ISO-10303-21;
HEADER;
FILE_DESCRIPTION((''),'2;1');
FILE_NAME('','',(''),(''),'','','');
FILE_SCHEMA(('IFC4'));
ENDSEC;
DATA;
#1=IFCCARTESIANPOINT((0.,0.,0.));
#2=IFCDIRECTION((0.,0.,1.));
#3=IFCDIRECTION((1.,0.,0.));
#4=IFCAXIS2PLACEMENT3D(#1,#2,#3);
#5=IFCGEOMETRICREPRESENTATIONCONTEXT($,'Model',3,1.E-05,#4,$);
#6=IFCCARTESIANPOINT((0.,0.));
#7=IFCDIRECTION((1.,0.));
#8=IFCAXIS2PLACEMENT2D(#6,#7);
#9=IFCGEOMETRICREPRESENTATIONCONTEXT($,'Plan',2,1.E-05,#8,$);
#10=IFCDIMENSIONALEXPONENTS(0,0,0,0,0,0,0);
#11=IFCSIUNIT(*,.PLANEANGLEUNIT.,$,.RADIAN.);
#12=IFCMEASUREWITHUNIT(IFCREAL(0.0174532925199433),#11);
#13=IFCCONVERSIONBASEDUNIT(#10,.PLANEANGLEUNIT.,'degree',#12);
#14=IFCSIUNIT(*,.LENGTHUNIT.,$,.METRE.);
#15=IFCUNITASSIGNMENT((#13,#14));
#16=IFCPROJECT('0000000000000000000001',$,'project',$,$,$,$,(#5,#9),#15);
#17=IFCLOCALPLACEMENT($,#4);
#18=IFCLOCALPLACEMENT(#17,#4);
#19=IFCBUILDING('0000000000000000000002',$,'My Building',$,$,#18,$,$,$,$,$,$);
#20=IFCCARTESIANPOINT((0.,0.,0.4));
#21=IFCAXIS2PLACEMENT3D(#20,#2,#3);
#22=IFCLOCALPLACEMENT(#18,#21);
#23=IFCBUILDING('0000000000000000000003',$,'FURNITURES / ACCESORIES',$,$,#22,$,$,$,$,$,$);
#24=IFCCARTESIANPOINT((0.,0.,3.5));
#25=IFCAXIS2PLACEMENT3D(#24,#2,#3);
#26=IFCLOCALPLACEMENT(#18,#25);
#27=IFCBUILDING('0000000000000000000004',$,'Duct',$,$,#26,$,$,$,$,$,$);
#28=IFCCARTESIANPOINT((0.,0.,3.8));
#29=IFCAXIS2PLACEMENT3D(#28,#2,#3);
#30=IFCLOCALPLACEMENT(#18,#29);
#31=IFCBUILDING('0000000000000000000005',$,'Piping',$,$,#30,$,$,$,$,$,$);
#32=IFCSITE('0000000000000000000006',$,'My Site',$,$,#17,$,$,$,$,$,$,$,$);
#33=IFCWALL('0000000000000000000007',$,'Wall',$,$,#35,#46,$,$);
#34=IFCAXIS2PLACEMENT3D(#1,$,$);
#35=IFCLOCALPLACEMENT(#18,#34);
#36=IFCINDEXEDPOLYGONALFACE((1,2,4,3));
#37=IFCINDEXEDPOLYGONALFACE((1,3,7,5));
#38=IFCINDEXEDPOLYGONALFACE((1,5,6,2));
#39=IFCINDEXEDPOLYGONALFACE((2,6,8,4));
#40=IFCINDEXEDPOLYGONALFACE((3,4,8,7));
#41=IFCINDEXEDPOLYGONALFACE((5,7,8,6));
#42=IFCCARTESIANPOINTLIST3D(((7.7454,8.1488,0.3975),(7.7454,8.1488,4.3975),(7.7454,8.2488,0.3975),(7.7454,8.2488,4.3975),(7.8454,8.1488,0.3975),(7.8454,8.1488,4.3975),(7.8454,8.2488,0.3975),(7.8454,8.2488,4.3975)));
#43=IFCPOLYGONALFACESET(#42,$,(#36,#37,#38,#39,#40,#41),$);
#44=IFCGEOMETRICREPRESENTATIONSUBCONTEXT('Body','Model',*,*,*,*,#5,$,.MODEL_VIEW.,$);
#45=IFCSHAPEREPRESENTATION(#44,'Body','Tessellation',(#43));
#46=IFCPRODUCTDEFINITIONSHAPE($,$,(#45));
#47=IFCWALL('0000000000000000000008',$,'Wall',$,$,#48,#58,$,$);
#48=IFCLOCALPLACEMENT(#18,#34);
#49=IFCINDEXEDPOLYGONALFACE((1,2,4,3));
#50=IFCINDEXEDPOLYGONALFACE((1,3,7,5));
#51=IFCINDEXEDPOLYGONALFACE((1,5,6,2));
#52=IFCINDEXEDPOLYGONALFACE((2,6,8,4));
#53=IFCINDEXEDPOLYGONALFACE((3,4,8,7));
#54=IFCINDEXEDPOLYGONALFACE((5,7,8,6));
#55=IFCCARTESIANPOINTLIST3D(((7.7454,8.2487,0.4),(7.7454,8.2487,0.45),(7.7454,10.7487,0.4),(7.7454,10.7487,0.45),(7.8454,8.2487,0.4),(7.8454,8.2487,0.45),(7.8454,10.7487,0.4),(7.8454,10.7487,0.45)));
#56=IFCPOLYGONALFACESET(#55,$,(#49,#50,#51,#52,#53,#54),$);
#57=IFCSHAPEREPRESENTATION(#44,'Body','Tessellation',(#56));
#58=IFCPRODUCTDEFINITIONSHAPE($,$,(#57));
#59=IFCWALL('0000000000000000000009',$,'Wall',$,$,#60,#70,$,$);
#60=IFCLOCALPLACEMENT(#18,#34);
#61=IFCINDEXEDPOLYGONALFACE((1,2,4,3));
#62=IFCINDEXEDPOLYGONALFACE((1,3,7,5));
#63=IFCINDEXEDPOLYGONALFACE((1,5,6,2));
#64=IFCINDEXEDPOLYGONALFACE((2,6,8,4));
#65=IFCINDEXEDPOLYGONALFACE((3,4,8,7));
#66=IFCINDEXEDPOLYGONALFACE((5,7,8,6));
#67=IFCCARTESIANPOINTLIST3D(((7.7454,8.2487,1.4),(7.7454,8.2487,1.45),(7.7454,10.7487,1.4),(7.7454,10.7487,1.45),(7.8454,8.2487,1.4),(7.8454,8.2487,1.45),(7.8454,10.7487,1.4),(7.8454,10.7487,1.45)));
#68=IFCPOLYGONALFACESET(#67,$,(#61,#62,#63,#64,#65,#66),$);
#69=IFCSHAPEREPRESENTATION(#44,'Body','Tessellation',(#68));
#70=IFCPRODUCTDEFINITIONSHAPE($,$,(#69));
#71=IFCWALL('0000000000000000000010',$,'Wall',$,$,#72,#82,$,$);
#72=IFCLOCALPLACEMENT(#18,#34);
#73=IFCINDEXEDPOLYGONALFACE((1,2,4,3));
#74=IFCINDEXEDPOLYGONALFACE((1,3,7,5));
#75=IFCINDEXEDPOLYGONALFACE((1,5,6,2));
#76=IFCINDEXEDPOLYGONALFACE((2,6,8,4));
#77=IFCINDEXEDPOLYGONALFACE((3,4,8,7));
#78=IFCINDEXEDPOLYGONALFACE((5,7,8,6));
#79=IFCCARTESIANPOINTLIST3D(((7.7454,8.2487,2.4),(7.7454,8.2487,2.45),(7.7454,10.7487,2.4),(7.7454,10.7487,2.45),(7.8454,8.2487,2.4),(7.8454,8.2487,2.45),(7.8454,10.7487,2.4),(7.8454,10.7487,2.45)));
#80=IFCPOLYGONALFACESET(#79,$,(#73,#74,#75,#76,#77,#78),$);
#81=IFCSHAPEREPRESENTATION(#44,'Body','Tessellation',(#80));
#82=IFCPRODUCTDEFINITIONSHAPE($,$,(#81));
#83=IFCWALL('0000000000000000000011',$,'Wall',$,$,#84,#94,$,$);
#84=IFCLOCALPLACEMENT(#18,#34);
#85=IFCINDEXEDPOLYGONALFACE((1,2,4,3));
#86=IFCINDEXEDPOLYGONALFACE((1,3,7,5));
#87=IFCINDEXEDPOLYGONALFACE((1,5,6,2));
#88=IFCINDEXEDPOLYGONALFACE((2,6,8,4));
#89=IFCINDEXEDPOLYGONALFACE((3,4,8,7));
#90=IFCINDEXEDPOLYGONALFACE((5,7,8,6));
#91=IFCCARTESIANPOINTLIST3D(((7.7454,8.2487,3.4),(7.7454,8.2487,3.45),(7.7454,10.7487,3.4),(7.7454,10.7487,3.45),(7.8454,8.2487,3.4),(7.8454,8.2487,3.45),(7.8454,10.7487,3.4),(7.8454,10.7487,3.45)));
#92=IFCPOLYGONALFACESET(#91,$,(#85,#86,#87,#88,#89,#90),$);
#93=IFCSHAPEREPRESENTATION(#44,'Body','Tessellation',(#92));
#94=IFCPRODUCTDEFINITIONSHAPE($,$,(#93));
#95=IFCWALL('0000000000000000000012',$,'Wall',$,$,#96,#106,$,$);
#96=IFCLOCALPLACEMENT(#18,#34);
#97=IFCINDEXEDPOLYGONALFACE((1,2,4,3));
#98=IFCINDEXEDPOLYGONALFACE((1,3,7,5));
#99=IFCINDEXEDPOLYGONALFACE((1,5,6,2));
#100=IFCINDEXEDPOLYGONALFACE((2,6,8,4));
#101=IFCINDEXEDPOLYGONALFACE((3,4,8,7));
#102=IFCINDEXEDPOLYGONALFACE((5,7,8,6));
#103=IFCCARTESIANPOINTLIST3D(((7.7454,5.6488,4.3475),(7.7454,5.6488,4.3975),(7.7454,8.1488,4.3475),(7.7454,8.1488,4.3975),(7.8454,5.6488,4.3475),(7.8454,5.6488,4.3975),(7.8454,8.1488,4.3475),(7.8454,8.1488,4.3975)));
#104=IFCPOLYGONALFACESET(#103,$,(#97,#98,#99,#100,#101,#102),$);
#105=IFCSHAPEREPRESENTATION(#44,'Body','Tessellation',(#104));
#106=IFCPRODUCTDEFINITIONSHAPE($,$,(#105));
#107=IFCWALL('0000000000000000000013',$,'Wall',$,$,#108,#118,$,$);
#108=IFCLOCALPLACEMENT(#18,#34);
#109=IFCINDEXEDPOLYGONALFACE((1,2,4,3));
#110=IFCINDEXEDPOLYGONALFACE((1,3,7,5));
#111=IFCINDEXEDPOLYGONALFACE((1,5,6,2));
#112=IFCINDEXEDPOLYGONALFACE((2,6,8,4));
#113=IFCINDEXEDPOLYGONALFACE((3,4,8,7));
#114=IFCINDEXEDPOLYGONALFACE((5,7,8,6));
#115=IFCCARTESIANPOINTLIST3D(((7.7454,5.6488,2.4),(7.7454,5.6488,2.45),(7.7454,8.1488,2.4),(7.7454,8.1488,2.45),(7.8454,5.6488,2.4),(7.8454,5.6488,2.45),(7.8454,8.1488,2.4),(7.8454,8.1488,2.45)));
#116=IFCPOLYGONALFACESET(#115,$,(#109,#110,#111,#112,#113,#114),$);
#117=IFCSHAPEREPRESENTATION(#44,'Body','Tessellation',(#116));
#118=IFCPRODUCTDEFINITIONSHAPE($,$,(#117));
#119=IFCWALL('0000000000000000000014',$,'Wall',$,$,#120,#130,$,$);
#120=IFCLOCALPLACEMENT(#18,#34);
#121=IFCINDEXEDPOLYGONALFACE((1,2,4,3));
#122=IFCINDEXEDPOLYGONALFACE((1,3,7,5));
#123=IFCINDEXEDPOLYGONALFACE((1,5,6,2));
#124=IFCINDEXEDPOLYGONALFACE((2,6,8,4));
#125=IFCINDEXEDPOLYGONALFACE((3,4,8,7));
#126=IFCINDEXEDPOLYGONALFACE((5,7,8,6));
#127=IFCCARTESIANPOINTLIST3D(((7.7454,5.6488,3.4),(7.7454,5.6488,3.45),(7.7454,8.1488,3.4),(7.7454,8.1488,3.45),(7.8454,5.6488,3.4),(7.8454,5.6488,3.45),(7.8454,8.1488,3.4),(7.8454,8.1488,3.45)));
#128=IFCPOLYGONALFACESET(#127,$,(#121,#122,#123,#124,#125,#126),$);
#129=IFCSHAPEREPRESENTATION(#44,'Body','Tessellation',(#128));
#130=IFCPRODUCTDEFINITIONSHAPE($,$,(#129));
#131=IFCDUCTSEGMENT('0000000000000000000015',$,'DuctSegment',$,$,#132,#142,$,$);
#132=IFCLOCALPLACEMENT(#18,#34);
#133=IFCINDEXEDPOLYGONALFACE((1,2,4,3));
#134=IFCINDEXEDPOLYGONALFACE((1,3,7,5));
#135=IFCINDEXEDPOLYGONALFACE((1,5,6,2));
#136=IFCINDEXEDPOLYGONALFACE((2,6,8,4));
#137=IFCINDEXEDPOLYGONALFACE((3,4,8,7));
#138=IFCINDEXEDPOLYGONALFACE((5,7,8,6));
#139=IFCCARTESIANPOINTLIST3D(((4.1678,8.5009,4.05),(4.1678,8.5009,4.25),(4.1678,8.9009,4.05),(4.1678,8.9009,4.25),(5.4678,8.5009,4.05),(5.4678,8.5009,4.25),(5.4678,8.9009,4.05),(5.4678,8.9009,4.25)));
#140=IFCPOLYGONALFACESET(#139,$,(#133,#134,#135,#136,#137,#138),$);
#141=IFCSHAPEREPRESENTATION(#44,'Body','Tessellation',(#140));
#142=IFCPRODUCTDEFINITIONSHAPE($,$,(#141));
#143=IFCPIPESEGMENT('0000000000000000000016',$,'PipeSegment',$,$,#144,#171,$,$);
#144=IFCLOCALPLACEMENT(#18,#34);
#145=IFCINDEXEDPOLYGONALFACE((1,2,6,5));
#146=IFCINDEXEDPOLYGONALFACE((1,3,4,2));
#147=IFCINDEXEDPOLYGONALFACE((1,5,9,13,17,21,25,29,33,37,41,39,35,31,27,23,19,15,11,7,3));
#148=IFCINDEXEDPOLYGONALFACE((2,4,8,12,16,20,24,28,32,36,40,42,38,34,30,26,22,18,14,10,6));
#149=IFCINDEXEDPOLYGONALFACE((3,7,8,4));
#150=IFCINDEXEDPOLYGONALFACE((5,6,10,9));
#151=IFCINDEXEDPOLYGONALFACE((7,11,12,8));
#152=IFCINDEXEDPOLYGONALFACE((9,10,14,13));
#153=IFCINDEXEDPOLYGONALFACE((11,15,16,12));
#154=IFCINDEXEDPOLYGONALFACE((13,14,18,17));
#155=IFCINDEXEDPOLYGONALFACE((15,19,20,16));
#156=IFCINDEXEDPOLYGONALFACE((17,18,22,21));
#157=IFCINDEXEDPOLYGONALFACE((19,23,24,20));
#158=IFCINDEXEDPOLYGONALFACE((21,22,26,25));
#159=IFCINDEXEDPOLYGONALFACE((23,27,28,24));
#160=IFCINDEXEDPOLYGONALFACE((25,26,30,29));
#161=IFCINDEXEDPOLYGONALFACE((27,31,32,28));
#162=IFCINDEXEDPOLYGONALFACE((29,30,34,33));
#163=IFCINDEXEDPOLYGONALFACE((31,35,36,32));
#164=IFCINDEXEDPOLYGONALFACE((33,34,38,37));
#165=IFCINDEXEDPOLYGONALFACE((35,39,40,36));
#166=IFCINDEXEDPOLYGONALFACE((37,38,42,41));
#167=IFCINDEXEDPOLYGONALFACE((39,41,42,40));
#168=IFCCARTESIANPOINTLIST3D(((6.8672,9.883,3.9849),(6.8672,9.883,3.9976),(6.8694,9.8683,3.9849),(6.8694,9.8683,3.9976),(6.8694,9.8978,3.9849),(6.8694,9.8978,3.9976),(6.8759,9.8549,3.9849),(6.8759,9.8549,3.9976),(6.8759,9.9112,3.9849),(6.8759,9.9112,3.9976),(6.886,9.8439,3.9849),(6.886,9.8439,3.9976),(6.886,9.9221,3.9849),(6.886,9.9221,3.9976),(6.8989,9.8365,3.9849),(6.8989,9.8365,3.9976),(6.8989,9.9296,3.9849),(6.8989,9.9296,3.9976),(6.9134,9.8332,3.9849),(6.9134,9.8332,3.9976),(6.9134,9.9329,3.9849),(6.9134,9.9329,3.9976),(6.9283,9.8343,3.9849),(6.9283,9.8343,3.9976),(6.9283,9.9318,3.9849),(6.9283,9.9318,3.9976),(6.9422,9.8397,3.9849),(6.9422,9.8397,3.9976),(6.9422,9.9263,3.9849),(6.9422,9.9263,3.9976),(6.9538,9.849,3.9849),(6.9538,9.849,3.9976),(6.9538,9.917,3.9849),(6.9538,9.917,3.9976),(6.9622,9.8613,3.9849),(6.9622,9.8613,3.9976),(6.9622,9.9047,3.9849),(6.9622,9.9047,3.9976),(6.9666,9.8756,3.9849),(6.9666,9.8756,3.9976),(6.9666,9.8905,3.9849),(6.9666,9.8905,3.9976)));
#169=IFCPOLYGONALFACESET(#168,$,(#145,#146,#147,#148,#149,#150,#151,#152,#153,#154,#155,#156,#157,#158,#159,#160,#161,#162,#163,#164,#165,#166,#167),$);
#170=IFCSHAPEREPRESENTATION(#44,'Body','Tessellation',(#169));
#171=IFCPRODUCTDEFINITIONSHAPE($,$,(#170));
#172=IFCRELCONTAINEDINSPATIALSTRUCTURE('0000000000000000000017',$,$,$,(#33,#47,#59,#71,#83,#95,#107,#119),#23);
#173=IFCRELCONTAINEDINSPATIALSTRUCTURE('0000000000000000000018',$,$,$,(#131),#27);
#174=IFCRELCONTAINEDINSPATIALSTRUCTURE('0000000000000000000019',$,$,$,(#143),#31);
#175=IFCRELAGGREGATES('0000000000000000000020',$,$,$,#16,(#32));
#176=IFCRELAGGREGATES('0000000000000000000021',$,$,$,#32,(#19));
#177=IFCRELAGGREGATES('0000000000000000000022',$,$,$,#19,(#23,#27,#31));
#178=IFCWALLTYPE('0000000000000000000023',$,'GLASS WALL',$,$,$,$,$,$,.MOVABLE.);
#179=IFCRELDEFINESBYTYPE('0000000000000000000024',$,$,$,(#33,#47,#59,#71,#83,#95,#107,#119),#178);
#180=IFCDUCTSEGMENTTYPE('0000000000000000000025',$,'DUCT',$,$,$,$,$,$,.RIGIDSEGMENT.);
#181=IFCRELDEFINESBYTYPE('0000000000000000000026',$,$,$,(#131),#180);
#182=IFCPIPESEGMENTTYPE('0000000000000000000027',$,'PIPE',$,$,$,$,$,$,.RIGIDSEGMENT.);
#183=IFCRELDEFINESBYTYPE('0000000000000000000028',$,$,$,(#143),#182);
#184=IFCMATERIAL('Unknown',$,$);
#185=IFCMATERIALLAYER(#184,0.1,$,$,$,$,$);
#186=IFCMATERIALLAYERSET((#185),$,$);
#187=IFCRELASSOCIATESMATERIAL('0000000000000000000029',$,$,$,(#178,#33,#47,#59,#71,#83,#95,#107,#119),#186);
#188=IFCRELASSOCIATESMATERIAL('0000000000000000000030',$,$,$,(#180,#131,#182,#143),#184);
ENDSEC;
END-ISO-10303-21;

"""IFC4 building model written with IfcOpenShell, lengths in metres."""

from ifc_helpers import new_model, entity, si_unit, converted_unit, frame, origin_with_axes, origin_2d_with_axis, place, context, subcontext, project, spatial, line, indexed_curve, rectangle, circle, outline, extrude, material, layer, layer_set, layer_usage, material_profile, profile_set, profile_usage, type_object, element, save


model = new_model("IFC4")

# Units and contexts
model_context = context("Model", 3, precision=1e-05, world=origin_with_axes())
plan_context = context("Plan", 2, precision=1e-05, world=origin_2d_with_axis())
body_context_1 = subcontext(model_context, "Body", "Model", "MODEL_VIEW")
ifc_project = project(units=[converted_unit("PLANEANGLEUNIT", "degree", entity("IfcReal", 0.0174532925199433), si_unit("PLANEANGLEUNIT", "RADIAN"), dimensions=[0, 0, 0, 0, 0, 0, 0]), si_unit("LENGTHUNIT", "METRE")], contexts=[model_context, plan_context])

# Site, building
site_placement = place(None, origin_with_axes())
site = spatial("IfcSite", under=ifc_project, at=site_placement, Name="My Site")
building_1_placement = place(site_placement, origin_with_axes())
building_1 = spatial("IfcBuilding", under=site, at=building_1_placement, Name="My Building")

# Shared definitions
ifc_material = material(Name="Unknown")

# Shared definitions
building_2_placement = place(building_1_placement, frame((0.0, 0.0, 0.4), z_axis=(0.0, 0.0, 1.0), x_axis=(1.0, 0.0, 0.0)))
building_2 = spatial("IfcBuilding", under=building_1, at=building_2_placement, Name="FURNITURES / ACCESORIES")

# Walls
ifc_layer_1 = layer(ifc_material, 0.1)
ifc_layer_set_1 = layer_set([ifc_layer_1])
ifc_layer_usage_1 = layer_usage(ifc_layer_set_1, "AXIS2", "POSITIVE", 0.0)
wall_type_1 = type_object("IfcWallType", Name="GLASS WALL", PredefinedType="MOVABLE", material=ifc_layer_set_1)
wall_1_placement = place(building_2_placement, frame((7.7454, 8.2488, -0.0025), z_axis=(0.0, 0.0, 1.0), x_axis=(0.0, -1.0, 0.0)))
element("IfcWall", 1, at=wall_1_placement, inside=building_2, type_object=wall_type_1, material=ifc_layer_usage_1, Name="Wall", context=body_context_1, shape_type="SweptSolid", body=[
    extrude(outline(indexed_curve([(0.0, 0.0), (0.0, 0.1), (0.1, 0.1), (0.1, 0.0)], segments=[line(1, 2, 3, 4, 1)])), origin_with_axes(), (0.0, 0.0, 1.0), 4.0),
])
ifc_layer_usage_2 = layer_usage(ifc_layer_set_1, "AXIS2", "POSITIVE", 0.0)
wall_2_placement = place(building_2_placement, frame((7.7454, 10.7487, 0.0), z_axis=(0.0, 0.0, 1.0), x_axis=(0.0, -1.0, 0.0)))
element("IfcWall", 2, at=wall_2_placement, inside=building_2, type_object=wall_type_1, material=ifc_layer_usage_2, Name="Wall", context=body_context_1, shape_type="SweptSolid", body=[
    extrude(outline(indexed_curve([(0.0, 0.0), (0.0, 0.1), (2.5, 0.1), (2.5, 0.0)], segments=[line(1, 2, 3, 4, 1)])), origin_with_axes(), (0.0, 0.0, 1.0), 0.05),
])
ifc_layer_usage_3 = layer_usage(ifc_layer_set_1, "AXIS2", "POSITIVE", 0.0)
wall_3_placement = place(building_2_placement, frame((7.7454, 10.7487, 1.0), z_axis=(0.0, 0.0, 1.0), x_axis=(0.0, -1.0, 0.0)))
element("IfcWall", 3, at=wall_3_placement, inside=building_2, type_object=wall_type_1, material=ifc_layer_usage_3, Name="Wall", context=body_context_1, shape_type="SweptSolid", body=[
    extrude(outline(indexed_curve([(0.0, 0.0), (0.0, 0.1), (2.5, 0.1), (2.5, 0.0)], segments=[line(1, 2, 3, 4, 1)])), origin_with_axes(), (0.0, 0.0, 1.0), 0.05),
])
ifc_layer_usage_4 = layer_usage(ifc_layer_set_1, "AXIS2", "POSITIVE", 0.0)
wall_4_placement = place(building_2_placement, frame((7.7454, 10.7487, 2.0), z_axis=(0.0, 0.0, 1.0), x_axis=(0.0, -1.0, 0.0)))
element("IfcWall", 4, at=wall_4_placement, inside=building_2, type_object=wall_type_1, material=ifc_layer_usage_4, Name="Wall", context=body_context_1, shape_type="SweptSolid", body=[
    extrude(outline(indexed_curve([(0.0, 0.0), (0.0, 0.1), (2.5, 0.1), (2.5, 0.0)], segments=[line(1, 2, 3, 4, 1)])), origin_with_axes(), (0.0, 0.0, 1.0), 0.05),
])
ifc_layer_usage_5 = layer_usage(ifc_layer_set_1, "AXIS2", "POSITIVE", 0.0)
wall_5_placement = place(building_2_placement, frame((7.7454, 10.7487, 3.0), z_axis=(0.0, 0.0, 1.0), x_axis=(0.0, -1.0, 0.0)))
element("IfcWall", 5, at=wall_5_placement, inside=building_2, type_object=wall_type_1, material=ifc_layer_usage_5, Name="Wall", context=body_context_1, shape_type="SweptSolid", body=[
    extrude(outline(indexed_curve([(0.0, 0.0), (0.0, 0.1), (2.5, 0.1), (2.5, 0.0)], segments=[line(1, 2, 3, 4, 1)])), origin_with_axes(), (0.0, 0.0, 1.0), 0.05),
])
ifc_layer_usage_6 = layer_usage(ifc_layer_set_1, "AXIS2", "POSITIVE", 0.0)
wall_6_placement = place(building_2_placement, frame((7.7454, 8.1488, 3.9475), z_axis=(0.0, 0.0, 1.0), x_axis=(0.0, -1.0, 0.0)))
element("IfcWall", 6, at=wall_6_placement, inside=building_2, type_object=wall_type_1, material=ifc_layer_usage_6, Name="Wall", context=body_context_1, shape_type="SweptSolid", body=[
    extrude(outline(indexed_curve([(0.0, 0.0), (0.0, 0.1), (2.5, 0.1), (2.5, 0.0)], segments=[line(1, 2, 3, 4, 1)])), origin_with_axes(), (0.0, 0.0, 1.0), 0.05),
])
ifc_layer_usage_7 = layer_usage(ifc_layer_set_1, "AXIS2", "POSITIVE", 0.0)
wall_7_placement = place(building_2_placement, frame((7.7454, 8.1488, 2.0), z_axis=(0.0, 0.0, 1.0), x_axis=(0.0, -1.0, 0.0)))
element("IfcWall", 7, at=wall_7_placement, inside=building_2, type_object=wall_type_1, material=ifc_layer_usage_7, Name="Wall", context=body_context_1, shape_type="SweptSolid", body=[
    extrude(outline(indexed_curve([(0.0, 0.0), (0.0, 0.1), (2.5, 0.1), (2.5, 0.0)], segments=[line(1, 2, 3, 4, 1)])), origin_with_axes(), (0.0, 0.0, 1.0), 0.05),
])
ifc_layer_usage_8 = layer_usage(ifc_layer_set_1, "AXIS2", "POSITIVE", 0.0)
wall_8_placement = place(building_2_placement, frame((7.7454, 8.1488, 3.0), z_axis=(0.0, 0.0, 1.0), x_axis=(0.0, -1.0, 0.0)))
element("IfcWall", 8, at=wall_8_placement, inside=building_2, type_object=wall_type_1, material=ifc_layer_usage_8, Name="Wall", context=body_context_1, shape_type="SweptSolid", body=[
    extrude(outline(indexed_curve([(0.0, 0.0), (0.0, 0.1), (2.5, 0.1), (2.5, 0.0)], segments=[line(1, 2, 3, 4, 1)])), origin_with_axes(), (0.0, 0.0, 1.0), 0.05),
])

# Shared definitions
building_3_placement = place(building_1_placement, frame((0.0, 0.0, 3.5), z_axis=(0.0, 0.0, 1.0), x_axis=(1.0, 0.0, 0.0)))
building_3 = spatial("IfcBuilding", under=building_1, at=building_3_placement, Name="Duct")

# Duct segment
ifc_material_profile_1 = material_profile(ifc_material, rectangle(XDim=0.4, YDim=0.2))
ifc_profile_set_1 = profile_set([ifc_material_profile_1])
ifc_profile_usage_1 = profile_usage(ifc_profile_set_1, cardinal=5)
duct_segment_type = type_object("IfcDuctSegmentType", Name="DUCT", PredefinedType="RIGIDSEGMENT", material=ifc_profile_set_1)
duct_segment_placement = place(building_3_placement, frame((5.4678, 8.7009, 0.65), z_axis=(-1.0, 0.0, 0.0), x_axis=(0.0, 1.0, 0.0)))
element("IfcDuctSegment", 9, at=duct_segment_placement, inside=building_3, type_object=duct_segment_type, material=ifc_profile_usage_1, Name="DuctSegment", context=body_context_1, shape_type="SweptSolid", body=[
    extrude(rectangle(XDim=0.4, YDim=0.2), origin_with_axes(), (0.0, 0.0, 1.0), 1.3),
])

# Shared definitions
building_4_placement = place(building_1_placement, frame((0.0, 0.0, 3.8), z_axis=(0.0, 0.0, 1.0), x_axis=(1.0, 0.0, 0.0)))
building_4 = spatial("IfcBuilding", under=building_1, at=building_4_placement, Name="Piping")

# Pipe segment
ifc_material_profile_2 = material_profile(ifc_material, circle(Radius=0.05))
ifc_profile_set_2 = profile_set([ifc_material_profile_2])
ifc_profile_usage_2 = profile_usage(ifc_profile_set_2, cardinal=5)
pipe_segment_type = type_object("IfcPipeSegmentType", Name="PIPE", PredefinedType="RIGIDSEGMENT", material=ifc_profile_set_2)
pipe_segment_1_placement = place(building_4_placement, frame((6.9172, 9.883, 0.1976), z_axis=(0.0, 0.0, -1.0), x_axis=(-1.0, 0.0, 0.0)))
element("IfcPipeSegment", 10, at=pipe_segment_1_placement, inside=building_4, type_object=pipe_segment_type, material=ifc_profile_usage_2, Name="PipeSegment", context=body_context_1, shape_type="SweptSolid", body=[
    extrude(circle(Radius=0.05), origin_with_axes(), (0.0, 0.0, 1.0), 0.0127),
])

save(model, "model.ifc")
